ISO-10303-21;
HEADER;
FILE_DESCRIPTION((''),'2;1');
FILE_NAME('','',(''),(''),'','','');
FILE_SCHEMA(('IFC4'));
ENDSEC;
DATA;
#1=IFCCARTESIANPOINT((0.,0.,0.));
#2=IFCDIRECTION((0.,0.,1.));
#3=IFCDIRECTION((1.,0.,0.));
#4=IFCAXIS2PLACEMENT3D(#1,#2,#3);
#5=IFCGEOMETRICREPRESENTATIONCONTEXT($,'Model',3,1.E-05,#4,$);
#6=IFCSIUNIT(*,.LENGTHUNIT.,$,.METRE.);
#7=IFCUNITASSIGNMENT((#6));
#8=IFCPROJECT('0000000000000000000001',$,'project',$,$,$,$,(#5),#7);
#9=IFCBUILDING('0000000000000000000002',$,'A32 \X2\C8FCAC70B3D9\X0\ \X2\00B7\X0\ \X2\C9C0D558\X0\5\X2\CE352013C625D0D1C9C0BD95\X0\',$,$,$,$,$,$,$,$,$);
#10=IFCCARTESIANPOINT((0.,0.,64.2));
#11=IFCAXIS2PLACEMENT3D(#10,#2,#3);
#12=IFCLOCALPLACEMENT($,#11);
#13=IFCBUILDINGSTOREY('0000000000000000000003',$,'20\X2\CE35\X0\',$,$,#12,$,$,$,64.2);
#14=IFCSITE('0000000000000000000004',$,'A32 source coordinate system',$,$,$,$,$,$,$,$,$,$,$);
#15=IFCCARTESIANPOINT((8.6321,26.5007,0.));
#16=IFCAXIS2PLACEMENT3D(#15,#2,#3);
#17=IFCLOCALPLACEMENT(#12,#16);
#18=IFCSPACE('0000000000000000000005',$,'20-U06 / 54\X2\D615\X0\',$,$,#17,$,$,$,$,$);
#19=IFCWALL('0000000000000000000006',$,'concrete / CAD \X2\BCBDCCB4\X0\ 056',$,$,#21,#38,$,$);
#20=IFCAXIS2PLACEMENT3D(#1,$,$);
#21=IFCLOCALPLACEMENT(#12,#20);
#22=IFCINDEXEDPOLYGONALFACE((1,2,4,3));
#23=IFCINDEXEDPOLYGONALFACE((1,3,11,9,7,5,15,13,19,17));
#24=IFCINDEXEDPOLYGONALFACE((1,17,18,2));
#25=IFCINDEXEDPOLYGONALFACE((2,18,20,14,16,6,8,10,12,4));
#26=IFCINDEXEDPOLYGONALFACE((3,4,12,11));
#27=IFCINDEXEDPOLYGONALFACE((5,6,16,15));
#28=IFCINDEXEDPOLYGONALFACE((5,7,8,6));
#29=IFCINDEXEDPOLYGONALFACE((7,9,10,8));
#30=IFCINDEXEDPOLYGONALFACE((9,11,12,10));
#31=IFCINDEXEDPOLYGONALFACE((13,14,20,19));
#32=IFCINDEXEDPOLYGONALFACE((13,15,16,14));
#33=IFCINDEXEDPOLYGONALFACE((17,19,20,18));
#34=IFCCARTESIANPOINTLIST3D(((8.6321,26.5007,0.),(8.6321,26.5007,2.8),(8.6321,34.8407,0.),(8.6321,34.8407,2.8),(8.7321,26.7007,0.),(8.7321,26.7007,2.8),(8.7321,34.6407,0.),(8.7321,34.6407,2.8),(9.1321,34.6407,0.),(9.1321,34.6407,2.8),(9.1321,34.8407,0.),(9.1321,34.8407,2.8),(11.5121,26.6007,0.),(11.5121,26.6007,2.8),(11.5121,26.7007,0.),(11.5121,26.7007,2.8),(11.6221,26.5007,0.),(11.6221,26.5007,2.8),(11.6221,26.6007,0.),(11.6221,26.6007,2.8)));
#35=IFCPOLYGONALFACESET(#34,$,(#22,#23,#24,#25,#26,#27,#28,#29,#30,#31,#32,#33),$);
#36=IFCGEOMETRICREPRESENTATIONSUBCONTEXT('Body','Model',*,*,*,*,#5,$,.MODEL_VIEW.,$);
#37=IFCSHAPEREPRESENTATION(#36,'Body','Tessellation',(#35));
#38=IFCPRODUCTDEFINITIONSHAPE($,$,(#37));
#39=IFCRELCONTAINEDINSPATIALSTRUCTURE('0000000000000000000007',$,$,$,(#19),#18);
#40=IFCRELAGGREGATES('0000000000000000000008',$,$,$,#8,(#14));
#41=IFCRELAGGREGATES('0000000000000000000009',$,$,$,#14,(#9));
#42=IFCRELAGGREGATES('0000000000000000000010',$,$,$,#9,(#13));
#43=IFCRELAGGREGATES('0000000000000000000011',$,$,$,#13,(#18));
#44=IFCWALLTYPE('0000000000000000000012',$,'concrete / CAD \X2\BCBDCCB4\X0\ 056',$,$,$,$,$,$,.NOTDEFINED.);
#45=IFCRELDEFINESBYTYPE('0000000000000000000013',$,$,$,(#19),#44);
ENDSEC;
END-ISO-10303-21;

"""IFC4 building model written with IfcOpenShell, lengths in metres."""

from ifc_helpers import new_model, si_unit, frame, origin, origin_with_axes, place, context, subcontext, project, spatial, polyline, outline, extrude, source, transform, mapped, type_object, type_shapes, element, save


model = new_model("IFC4")

# Units and contexts
model_context = context("Model", 3, precision=1e-05, world=origin_with_axes())
body_context = subcontext(model_context, "Body", "Model", "MODEL_VIEW")
ifc_project = project(units=[si_unit("LENGTHUNIT", "METRE")], contexts=[model_context])

# Site, building, storey, space
site = spatial("IfcSite", under=ifc_project, Name="A32 source coordinate system")
building = spatial("IfcBuilding", under=site, Name="A32 주거동 · 지하5층–옥탑지붕")
storey_placement = place(None, frame((0.0, 0.0, 64.2), z_axis=(0.0, 0.0, 1.0), x_axis=(1.0, 0.0, 0.0)))
storey = spatial("IfcBuildingStorey", under=building, at=storey_placement, Name="20층", Elevation=64.2)
space_placement = place(storey_placement, frame((8.6321, 26.5007, 0.0), z_axis=(0.0, 0.0, 1.0), x_axis=(1.0, 0.0, 0.0)))
space = spatial("IfcSpace", under=storey, at=space_placement, Name="20-U06 / 54형")

# Wall
wall_type_1 = type_object("IfcWallType", Name="concrete / CAD 벽체 056", PredefinedType="NOTDEFINED")
shared_shape_1 = source(origin(), body_context, "Body", "SweptSolid", [
    extrude(outline(polyline([(0.1, 8.14), (0.1, 0.2), (2.88, 0.2), (2.88, 0.1), (2.99, 0.1), (2.99, 0.0), (0.0, 0.0), (0.0, 8.34), (-0.35, 8.34), (-0.35, 8.34), (0.5, 8.34), (0.5, 8.14), (0.1, 8.14)])), origin(), (0.0, 0.0, 1.0), 2.8),
])
type_shapes(wall_type_1, [shared_shape_1])
wall_1_placement = place(space_placement, origin_with_axes())
element("IfcWall", 1, at=wall_1_placement, inside=space, type_object=wall_type_1, Name="concrete / CAD 벽체 056", context=body_context, shape_type="MappedRepresentation", body=[
    mapped(shared_shape_1, transform((0.0, 0.0, 0.0), scale=1.0)),
])

save(model, "model.ifc")
